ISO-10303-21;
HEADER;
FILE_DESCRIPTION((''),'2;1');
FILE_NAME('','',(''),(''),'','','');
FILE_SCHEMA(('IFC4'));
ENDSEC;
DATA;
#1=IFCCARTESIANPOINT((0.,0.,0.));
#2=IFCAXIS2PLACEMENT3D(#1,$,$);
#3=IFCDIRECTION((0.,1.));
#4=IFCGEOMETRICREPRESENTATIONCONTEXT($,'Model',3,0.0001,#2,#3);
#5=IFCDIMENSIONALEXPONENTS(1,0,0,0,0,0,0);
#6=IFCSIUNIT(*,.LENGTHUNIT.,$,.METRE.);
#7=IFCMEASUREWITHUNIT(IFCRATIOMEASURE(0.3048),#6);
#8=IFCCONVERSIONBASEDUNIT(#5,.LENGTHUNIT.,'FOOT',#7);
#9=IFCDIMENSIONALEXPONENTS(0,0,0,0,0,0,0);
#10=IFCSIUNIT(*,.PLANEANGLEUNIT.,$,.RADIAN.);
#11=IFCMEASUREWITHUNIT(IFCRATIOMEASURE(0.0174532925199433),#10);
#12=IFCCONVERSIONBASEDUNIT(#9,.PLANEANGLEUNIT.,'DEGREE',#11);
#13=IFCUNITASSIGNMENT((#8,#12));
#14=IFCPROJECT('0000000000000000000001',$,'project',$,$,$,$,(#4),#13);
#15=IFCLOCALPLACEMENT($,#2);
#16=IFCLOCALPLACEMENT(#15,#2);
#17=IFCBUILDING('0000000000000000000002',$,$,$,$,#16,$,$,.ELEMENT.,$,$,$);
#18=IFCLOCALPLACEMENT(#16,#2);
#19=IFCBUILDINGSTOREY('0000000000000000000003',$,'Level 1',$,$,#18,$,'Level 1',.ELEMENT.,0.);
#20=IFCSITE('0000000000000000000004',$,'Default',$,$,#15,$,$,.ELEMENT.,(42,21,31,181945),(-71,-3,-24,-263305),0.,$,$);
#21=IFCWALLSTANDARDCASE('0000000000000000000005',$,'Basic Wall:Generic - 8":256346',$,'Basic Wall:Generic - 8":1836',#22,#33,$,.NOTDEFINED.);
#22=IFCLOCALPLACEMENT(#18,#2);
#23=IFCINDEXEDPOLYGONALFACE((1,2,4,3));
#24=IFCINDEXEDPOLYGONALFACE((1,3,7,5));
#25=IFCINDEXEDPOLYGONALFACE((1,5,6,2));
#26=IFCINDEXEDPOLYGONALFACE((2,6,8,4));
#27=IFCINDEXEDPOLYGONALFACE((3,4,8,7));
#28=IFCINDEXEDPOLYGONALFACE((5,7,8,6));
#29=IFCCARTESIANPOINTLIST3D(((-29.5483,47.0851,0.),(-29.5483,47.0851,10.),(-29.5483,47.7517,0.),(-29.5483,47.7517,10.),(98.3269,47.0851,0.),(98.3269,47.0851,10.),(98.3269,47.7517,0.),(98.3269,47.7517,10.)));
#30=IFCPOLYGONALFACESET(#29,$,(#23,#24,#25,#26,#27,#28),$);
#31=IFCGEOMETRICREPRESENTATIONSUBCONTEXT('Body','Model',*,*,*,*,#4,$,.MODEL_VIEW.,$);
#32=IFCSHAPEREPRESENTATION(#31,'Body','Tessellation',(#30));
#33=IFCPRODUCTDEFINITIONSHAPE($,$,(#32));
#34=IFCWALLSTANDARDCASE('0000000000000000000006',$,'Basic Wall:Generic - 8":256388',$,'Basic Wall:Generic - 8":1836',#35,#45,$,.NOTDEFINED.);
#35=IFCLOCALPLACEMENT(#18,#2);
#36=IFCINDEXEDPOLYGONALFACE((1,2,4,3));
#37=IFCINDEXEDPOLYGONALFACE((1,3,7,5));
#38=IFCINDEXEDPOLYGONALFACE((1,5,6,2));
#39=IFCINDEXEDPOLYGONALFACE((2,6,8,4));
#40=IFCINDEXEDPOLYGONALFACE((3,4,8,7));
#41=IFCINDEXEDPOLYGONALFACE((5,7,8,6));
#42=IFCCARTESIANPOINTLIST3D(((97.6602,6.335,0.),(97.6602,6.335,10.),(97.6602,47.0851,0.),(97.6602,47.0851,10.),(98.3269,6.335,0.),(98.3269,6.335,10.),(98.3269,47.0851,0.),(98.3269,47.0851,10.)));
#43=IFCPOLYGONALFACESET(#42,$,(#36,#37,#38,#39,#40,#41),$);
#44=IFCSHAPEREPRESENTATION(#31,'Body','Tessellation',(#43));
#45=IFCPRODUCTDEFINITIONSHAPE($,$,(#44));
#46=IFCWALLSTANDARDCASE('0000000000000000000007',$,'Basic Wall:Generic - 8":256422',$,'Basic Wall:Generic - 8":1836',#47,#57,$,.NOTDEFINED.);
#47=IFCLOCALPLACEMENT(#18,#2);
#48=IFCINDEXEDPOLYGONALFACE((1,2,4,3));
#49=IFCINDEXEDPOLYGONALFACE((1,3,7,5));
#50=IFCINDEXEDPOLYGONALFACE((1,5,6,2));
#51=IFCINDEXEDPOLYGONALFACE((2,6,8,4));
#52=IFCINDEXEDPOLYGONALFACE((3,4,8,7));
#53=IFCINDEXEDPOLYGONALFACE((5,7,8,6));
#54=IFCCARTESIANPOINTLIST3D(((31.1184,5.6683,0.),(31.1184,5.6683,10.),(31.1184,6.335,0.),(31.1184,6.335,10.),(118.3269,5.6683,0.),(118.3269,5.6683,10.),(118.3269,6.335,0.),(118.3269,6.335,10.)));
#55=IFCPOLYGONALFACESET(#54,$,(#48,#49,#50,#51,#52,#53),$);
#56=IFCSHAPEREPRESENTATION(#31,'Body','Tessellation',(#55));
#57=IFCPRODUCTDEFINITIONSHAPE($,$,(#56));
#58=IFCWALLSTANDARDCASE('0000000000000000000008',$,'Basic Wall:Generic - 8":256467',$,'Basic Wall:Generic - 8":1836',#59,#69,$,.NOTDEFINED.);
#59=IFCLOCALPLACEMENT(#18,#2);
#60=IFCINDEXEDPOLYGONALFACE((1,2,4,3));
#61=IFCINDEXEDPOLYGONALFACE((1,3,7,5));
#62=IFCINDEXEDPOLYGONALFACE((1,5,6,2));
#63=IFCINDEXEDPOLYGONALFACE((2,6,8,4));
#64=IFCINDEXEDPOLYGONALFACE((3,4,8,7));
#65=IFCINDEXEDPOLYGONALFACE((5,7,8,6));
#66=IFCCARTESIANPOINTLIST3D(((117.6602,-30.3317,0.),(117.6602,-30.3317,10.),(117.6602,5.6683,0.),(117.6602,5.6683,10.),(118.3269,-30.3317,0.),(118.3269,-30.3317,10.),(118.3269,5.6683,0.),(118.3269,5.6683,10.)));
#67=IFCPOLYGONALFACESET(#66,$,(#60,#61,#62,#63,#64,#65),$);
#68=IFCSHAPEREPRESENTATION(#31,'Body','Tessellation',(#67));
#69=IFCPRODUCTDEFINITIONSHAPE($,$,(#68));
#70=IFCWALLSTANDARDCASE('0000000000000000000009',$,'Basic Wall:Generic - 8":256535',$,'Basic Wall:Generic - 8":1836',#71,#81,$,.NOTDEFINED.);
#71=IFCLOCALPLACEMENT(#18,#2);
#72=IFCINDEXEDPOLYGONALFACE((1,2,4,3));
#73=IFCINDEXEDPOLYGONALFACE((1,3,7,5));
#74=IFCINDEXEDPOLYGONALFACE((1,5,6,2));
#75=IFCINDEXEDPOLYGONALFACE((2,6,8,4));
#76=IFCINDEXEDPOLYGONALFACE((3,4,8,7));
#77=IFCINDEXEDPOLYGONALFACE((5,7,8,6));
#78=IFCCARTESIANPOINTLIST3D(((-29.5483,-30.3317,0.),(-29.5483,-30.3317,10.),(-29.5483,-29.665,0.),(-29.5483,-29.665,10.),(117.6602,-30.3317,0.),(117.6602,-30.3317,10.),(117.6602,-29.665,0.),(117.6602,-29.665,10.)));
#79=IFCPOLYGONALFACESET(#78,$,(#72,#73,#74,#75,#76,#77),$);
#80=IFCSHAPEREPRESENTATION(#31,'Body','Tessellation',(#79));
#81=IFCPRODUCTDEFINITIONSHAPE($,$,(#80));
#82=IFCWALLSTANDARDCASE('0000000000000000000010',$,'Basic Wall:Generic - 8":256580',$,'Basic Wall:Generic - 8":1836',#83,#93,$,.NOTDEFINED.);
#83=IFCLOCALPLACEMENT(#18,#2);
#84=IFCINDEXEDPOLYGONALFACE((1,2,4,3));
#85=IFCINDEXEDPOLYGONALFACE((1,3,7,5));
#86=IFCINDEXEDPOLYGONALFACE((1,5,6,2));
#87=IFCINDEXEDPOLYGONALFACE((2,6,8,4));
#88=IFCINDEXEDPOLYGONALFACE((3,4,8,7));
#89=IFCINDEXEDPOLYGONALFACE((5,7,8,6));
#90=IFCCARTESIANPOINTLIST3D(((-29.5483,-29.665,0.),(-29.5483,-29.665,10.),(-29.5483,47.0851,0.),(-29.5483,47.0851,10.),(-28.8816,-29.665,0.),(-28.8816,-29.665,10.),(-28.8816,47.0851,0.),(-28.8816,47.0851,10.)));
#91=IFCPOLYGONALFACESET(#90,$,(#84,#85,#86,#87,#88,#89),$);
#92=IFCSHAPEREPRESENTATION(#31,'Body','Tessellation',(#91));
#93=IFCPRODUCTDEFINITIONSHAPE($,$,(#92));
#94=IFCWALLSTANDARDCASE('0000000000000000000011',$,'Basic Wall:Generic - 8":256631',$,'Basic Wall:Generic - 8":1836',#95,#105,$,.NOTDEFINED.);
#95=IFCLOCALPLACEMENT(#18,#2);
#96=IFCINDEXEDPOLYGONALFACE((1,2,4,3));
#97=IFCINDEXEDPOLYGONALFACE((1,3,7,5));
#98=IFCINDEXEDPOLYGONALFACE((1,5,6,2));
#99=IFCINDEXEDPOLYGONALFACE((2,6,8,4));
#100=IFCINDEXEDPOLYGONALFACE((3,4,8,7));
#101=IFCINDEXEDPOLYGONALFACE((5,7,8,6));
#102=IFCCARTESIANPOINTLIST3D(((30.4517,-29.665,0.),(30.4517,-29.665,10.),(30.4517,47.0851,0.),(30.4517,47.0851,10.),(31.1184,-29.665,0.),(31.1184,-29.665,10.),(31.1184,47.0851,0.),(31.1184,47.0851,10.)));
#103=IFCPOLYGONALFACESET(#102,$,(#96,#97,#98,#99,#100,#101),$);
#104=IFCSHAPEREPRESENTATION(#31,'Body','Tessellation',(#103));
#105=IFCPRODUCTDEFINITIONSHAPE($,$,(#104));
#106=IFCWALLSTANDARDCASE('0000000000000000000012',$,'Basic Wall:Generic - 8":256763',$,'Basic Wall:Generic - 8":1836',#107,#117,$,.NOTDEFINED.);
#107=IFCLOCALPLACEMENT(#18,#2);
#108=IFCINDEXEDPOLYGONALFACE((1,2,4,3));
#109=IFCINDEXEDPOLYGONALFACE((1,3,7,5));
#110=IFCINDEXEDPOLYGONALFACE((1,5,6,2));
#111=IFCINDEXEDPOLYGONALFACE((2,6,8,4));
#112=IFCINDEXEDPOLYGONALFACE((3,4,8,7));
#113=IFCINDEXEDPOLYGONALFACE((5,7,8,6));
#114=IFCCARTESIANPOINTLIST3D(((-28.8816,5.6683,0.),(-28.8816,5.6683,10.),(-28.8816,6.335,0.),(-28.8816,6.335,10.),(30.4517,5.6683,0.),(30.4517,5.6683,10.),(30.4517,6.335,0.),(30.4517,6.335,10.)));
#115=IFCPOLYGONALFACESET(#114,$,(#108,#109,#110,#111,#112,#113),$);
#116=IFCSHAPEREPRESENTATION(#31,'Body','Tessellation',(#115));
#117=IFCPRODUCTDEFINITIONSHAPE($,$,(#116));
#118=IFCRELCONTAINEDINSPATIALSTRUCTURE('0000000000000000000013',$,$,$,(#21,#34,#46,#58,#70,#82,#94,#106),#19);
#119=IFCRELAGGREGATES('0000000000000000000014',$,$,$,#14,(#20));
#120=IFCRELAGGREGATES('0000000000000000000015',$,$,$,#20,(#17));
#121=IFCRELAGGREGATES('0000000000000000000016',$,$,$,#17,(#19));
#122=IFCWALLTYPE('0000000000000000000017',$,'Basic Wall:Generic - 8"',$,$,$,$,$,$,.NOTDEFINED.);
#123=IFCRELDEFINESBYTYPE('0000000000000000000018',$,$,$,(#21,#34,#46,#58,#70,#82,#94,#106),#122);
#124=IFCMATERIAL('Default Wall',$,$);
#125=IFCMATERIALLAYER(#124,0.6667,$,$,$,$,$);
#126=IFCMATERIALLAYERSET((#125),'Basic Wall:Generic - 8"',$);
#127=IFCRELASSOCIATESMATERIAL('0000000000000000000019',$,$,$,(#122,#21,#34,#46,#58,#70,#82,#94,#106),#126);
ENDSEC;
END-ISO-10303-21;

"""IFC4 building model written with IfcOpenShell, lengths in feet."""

from ifc_helpers import new_model, entity, si_unit, converted_unit, direction, frame, frame_2d, origin, place, context, subcontext, project, spatial, rectangle, extrude, material, layer, layer_set, layer_usage, type_object, element, save


model = new_model("IFC4")

# Units and contexts
model_context = context("Model", 3, precision=0.0001, world=origin(), true_north=direction((0.0, 1.0)))
body_context = subcontext(model_context, "Body", "Model", "MODEL_VIEW")
ifc_project = project(units=[converted_unit("LENGTHUNIT", "FOOT", entity("IfcRatioMeasure", 0.3048), si_unit("LENGTHUNIT", "METRE"), dimensions=[1, 0, 0, 0, 0, 0, 0]), converted_unit("PLANEANGLEUNIT", "DEGREE", entity("IfcRatioMeasure", 0.0174532925199433), si_unit("PLANEANGLEUNIT", "RADIAN"), dimensions=[0, 0, 0, 0, 0, 0, 0])], contexts=[model_context])

# Site, building, storey
site_placement = place(None, origin())
site = spatial("IfcSite", under=ifc_project, at=site_placement, Name="Default", CompositionType="ELEMENT", RefLatitude=(42, 21, 31, 181945), RefLongitude=(-71, -3, -24, -263305), RefElevation=0.0)
building_placement = place(site_placement, origin())
building = spatial("IfcBuilding", under=site, at=building_placement, CompositionType="ELEMENT")
storey_placement = place(building_placement, origin())
storey = spatial("IfcBuildingStorey", under=building, at=storey_placement, Name="Level 1", LongName="Level 1", CompositionType="ELEMENT", Elevation=0.0)

# Walls
ifc_material = material(Name="Default Wall")
ifc_layer = layer(ifc_material, 0.6667)
ifc_layer_set = layer_set([ifc_layer], Name="Basic Wall:Generic - 8\"")
ifc_layer_usage_1 = layer_usage(ifc_layer_set, "AXIS2", "NEGATIVE", 0.3333)
wall_type = type_object("IfcWallType", Name="Basic Wall:Generic - 8\"", PredefinedType="NOTDEFINED", material=ifc_layer_set)
wall_1_placement = place(storey_placement, frame((-29.5483, 47.4184, 0.0)))
element("IfcWallStandardCase", 1, at=wall_1_placement, inside=storey, type_object=wall_type, material=ifc_layer_usage_1, Name="Basic Wall:Generic - 8\":256346", ObjectType="Basic Wall:Generic - 8\":1836", PredefinedType="NOTDEFINED", context=body_context, shape_type="SweptSolid", body=[
    extrude(rectangle(XDim=127.8752, YDim=0.6667, at=frame_2d((63.9376, 0.0), x_axis=(-1.0, 0.0))), origin(), (0.0, 0.0, 1.0), 10.0),
])
ifc_layer_usage_2 = layer_usage(ifc_layer_set, "AXIS2", "NEGATIVE", 0.3333)
wall_2_placement = place(storey_placement, frame((97.9936, 47.0851, 0.0), z_axis=(0.0, 0.0, 1.0), x_axis=(0.0, -1.0, 0.0)))
element("IfcWallStandardCase", 2, at=wall_2_placement, inside=storey, type_object=wall_type, material=ifc_layer_usage_2, Name="Basic Wall:Generic - 8\":256388", ObjectType="Basic Wall:Generic - 8\":1836", PredefinedType="NOTDEFINED", context=body_context, shape_type="SweptSolid", body=[
    extrude(rectangle(XDim=40.7501, YDim=0.6667, at=frame_2d((20.375, 0.0), x_axis=(-1.0, 0.0))), origin(), (0.0, 0.0, 1.0), 10.0),
])
ifc_layer_usage_3 = layer_usage(ifc_layer_set, "AXIS2", "NEGATIVE", 0.3333)
wall_3_placement = place(storey_placement, frame((31.1184, 6.0017, 0.0)))
element("IfcWallStandardCase", 3, at=wall_3_placement, inside=storey, type_object=wall_type, material=ifc_layer_usage_3, Name="Basic Wall:Generic - 8\":256422", ObjectType="Basic Wall:Generic - 8\":1836", PredefinedType="NOTDEFINED", context=body_context, shape_type="SweptSolid", body=[
    extrude(rectangle(XDim=87.2085, YDim=0.6667, at=frame_2d((43.6043, 0.0), x_axis=(-1.0, 0.0))), origin(), (0.0, 0.0, 1.0), 10.0),
])
ifc_layer_usage_4 = layer_usage(ifc_layer_set, "AXIS2", "NEGATIVE", 0.3333)
wall_4_placement = place(storey_placement, frame((117.9936, 5.6683, 0.0), z_axis=(0.0, 0.0, 1.0), x_axis=(0.0, -1.0, 0.0)))
element("IfcWallStandardCase", 4, at=wall_4_placement, inside=storey, type_object=wall_type, material=ifc_layer_usage_4, Name="Basic Wall:Generic - 8\":256467", ObjectType="Basic Wall:Generic - 8\":1836", PredefinedType="NOTDEFINED", context=body_context, shape_type="SweptSolid", body=[
    extrude(rectangle(XDim=36.0, YDim=0.6667, at=frame_2d((18.0, 0.0), x_axis=(-1.0, 0.0))), origin(), (0.0, 0.0, 1.0), 10.0),
])
ifc_layer_usage_5 = layer_usage(ifc_layer_set, "AXIS2", "NEGATIVE", 0.3333)
wall_5_placement = place(storey_placement, frame((117.6602, -29.9983, 0.0), z_axis=(0.0, 0.0, 1.0), x_axis=(-1.0, 0.0, 0.0)))
element("IfcWallStandardCase", 5, at=wall_5_placement, inside=storey, type_object=wall_type, material=ifc_layer_usage_5, Name="Basic Wall:Generic - 8\":256535", ObjectType="Basic Wall:Generic - 8\":1836", PredefinedType="NOTDEFINED", context=body_context, shape_type="SweptSolid", body=[
    extrude(rectangle(XDim=147.2085, YDim=0.6667, at=frame_2d((73.6043, 0.0), x_axis=(-1.0, 0.0))), origin(), (0.0, 0.0, 1.0), 10.0),
])
ifc_layer_usage_6 = layer_usage(ifc_layer_set, "AXIS2", "NEGATIVE", 0.3333)
wall_6_placement = place(storey_placement, frame((-29.215, -29.665, 0.0), z_axis=(0.0, 0.0, 1.0), x_axis=(0.0, 1.0, 0.0)))
element("IfcWallStandardCase", 6, at=wall_6_placement, inside=storey, type_object=wall_type, material=ifc_layer_usage_6, Name="Basic Wall:Generic - 8\":256580", ObjectType="Basic Wall:Generic - 8\":1836", PredefinedType="NOTDEFINED", context=body_context, shape_type="SweptSolid", body=[
    extrude(rectangle(XDim=76.7501, YDim=0.6667, at=frame_2d((38.375, 0.0), x_axis=(-1.0, 0.0))), origin(), (0.0, 0.0, 1.0), 10.0),
])
ifc_layer_usage_7 = layer_usage(ifc_layer_set, "AXIS2", "NEGATIVE", 0.3333)
wall_7_placement = place(storey_placement, frame((30.785, 47.0851, 0.0), z_axis=(0.0, 0.0, 1.0), x_axis=(0.0, -1.0, 0.0)))
element("IfcWallStandardCase", 7, at=wall_7_placement, inside=storey, type_object=wall_type, material=ifc_layer_usage_7, Name="Basic Wall:Generic - 8\":256631", ObjectType="Basic Wall:Generic - 8\":1836", PredefinedType="NOTDEFINED", context=body_context, shape_type="SweptSolid", body=[
    extrude(rectangle(XDim=76.7501, YDim=0.6667, at=frame_2d((38.375, 0.0), x_axis=(-1.0, 0.0))), origin(), (0.0, 0.0, 1.0), 10.0),
])
ifc_layer_usage_8 = layer_usage(ifc_layer_set, "AXIS2", "NEGATIVE", 0.3333)
wall_8_placement = place(storey_placement, frame((30.4517, 6.0017, 0.0), z_axis=(0.0, 0.0, 1.0), x_axis=(-1.0, 0.0, 0.0)))
element("IfcWallStandardCase", 8, at=wall_8_placement, inside=storey, type_object=wall_type, material=ifc_layer_usage_8, Name="Basic Wall:Generic - 8\":256763", ObjectType="Basic Wall:Generic - 8\":1836", PredefinedType="NOTDEFINED", context=body_context, shape_type="SweptSolid", body=[
    extrude(rectangle(XDim=59.3333, YDim=0.6667, at=frame_2d((29.6667, 0.0), x_axis=(-1.0, 0.0))), origin(), (0.0, 0.0, 1.0), 10.0),
])

save(model, "model.ifc")
